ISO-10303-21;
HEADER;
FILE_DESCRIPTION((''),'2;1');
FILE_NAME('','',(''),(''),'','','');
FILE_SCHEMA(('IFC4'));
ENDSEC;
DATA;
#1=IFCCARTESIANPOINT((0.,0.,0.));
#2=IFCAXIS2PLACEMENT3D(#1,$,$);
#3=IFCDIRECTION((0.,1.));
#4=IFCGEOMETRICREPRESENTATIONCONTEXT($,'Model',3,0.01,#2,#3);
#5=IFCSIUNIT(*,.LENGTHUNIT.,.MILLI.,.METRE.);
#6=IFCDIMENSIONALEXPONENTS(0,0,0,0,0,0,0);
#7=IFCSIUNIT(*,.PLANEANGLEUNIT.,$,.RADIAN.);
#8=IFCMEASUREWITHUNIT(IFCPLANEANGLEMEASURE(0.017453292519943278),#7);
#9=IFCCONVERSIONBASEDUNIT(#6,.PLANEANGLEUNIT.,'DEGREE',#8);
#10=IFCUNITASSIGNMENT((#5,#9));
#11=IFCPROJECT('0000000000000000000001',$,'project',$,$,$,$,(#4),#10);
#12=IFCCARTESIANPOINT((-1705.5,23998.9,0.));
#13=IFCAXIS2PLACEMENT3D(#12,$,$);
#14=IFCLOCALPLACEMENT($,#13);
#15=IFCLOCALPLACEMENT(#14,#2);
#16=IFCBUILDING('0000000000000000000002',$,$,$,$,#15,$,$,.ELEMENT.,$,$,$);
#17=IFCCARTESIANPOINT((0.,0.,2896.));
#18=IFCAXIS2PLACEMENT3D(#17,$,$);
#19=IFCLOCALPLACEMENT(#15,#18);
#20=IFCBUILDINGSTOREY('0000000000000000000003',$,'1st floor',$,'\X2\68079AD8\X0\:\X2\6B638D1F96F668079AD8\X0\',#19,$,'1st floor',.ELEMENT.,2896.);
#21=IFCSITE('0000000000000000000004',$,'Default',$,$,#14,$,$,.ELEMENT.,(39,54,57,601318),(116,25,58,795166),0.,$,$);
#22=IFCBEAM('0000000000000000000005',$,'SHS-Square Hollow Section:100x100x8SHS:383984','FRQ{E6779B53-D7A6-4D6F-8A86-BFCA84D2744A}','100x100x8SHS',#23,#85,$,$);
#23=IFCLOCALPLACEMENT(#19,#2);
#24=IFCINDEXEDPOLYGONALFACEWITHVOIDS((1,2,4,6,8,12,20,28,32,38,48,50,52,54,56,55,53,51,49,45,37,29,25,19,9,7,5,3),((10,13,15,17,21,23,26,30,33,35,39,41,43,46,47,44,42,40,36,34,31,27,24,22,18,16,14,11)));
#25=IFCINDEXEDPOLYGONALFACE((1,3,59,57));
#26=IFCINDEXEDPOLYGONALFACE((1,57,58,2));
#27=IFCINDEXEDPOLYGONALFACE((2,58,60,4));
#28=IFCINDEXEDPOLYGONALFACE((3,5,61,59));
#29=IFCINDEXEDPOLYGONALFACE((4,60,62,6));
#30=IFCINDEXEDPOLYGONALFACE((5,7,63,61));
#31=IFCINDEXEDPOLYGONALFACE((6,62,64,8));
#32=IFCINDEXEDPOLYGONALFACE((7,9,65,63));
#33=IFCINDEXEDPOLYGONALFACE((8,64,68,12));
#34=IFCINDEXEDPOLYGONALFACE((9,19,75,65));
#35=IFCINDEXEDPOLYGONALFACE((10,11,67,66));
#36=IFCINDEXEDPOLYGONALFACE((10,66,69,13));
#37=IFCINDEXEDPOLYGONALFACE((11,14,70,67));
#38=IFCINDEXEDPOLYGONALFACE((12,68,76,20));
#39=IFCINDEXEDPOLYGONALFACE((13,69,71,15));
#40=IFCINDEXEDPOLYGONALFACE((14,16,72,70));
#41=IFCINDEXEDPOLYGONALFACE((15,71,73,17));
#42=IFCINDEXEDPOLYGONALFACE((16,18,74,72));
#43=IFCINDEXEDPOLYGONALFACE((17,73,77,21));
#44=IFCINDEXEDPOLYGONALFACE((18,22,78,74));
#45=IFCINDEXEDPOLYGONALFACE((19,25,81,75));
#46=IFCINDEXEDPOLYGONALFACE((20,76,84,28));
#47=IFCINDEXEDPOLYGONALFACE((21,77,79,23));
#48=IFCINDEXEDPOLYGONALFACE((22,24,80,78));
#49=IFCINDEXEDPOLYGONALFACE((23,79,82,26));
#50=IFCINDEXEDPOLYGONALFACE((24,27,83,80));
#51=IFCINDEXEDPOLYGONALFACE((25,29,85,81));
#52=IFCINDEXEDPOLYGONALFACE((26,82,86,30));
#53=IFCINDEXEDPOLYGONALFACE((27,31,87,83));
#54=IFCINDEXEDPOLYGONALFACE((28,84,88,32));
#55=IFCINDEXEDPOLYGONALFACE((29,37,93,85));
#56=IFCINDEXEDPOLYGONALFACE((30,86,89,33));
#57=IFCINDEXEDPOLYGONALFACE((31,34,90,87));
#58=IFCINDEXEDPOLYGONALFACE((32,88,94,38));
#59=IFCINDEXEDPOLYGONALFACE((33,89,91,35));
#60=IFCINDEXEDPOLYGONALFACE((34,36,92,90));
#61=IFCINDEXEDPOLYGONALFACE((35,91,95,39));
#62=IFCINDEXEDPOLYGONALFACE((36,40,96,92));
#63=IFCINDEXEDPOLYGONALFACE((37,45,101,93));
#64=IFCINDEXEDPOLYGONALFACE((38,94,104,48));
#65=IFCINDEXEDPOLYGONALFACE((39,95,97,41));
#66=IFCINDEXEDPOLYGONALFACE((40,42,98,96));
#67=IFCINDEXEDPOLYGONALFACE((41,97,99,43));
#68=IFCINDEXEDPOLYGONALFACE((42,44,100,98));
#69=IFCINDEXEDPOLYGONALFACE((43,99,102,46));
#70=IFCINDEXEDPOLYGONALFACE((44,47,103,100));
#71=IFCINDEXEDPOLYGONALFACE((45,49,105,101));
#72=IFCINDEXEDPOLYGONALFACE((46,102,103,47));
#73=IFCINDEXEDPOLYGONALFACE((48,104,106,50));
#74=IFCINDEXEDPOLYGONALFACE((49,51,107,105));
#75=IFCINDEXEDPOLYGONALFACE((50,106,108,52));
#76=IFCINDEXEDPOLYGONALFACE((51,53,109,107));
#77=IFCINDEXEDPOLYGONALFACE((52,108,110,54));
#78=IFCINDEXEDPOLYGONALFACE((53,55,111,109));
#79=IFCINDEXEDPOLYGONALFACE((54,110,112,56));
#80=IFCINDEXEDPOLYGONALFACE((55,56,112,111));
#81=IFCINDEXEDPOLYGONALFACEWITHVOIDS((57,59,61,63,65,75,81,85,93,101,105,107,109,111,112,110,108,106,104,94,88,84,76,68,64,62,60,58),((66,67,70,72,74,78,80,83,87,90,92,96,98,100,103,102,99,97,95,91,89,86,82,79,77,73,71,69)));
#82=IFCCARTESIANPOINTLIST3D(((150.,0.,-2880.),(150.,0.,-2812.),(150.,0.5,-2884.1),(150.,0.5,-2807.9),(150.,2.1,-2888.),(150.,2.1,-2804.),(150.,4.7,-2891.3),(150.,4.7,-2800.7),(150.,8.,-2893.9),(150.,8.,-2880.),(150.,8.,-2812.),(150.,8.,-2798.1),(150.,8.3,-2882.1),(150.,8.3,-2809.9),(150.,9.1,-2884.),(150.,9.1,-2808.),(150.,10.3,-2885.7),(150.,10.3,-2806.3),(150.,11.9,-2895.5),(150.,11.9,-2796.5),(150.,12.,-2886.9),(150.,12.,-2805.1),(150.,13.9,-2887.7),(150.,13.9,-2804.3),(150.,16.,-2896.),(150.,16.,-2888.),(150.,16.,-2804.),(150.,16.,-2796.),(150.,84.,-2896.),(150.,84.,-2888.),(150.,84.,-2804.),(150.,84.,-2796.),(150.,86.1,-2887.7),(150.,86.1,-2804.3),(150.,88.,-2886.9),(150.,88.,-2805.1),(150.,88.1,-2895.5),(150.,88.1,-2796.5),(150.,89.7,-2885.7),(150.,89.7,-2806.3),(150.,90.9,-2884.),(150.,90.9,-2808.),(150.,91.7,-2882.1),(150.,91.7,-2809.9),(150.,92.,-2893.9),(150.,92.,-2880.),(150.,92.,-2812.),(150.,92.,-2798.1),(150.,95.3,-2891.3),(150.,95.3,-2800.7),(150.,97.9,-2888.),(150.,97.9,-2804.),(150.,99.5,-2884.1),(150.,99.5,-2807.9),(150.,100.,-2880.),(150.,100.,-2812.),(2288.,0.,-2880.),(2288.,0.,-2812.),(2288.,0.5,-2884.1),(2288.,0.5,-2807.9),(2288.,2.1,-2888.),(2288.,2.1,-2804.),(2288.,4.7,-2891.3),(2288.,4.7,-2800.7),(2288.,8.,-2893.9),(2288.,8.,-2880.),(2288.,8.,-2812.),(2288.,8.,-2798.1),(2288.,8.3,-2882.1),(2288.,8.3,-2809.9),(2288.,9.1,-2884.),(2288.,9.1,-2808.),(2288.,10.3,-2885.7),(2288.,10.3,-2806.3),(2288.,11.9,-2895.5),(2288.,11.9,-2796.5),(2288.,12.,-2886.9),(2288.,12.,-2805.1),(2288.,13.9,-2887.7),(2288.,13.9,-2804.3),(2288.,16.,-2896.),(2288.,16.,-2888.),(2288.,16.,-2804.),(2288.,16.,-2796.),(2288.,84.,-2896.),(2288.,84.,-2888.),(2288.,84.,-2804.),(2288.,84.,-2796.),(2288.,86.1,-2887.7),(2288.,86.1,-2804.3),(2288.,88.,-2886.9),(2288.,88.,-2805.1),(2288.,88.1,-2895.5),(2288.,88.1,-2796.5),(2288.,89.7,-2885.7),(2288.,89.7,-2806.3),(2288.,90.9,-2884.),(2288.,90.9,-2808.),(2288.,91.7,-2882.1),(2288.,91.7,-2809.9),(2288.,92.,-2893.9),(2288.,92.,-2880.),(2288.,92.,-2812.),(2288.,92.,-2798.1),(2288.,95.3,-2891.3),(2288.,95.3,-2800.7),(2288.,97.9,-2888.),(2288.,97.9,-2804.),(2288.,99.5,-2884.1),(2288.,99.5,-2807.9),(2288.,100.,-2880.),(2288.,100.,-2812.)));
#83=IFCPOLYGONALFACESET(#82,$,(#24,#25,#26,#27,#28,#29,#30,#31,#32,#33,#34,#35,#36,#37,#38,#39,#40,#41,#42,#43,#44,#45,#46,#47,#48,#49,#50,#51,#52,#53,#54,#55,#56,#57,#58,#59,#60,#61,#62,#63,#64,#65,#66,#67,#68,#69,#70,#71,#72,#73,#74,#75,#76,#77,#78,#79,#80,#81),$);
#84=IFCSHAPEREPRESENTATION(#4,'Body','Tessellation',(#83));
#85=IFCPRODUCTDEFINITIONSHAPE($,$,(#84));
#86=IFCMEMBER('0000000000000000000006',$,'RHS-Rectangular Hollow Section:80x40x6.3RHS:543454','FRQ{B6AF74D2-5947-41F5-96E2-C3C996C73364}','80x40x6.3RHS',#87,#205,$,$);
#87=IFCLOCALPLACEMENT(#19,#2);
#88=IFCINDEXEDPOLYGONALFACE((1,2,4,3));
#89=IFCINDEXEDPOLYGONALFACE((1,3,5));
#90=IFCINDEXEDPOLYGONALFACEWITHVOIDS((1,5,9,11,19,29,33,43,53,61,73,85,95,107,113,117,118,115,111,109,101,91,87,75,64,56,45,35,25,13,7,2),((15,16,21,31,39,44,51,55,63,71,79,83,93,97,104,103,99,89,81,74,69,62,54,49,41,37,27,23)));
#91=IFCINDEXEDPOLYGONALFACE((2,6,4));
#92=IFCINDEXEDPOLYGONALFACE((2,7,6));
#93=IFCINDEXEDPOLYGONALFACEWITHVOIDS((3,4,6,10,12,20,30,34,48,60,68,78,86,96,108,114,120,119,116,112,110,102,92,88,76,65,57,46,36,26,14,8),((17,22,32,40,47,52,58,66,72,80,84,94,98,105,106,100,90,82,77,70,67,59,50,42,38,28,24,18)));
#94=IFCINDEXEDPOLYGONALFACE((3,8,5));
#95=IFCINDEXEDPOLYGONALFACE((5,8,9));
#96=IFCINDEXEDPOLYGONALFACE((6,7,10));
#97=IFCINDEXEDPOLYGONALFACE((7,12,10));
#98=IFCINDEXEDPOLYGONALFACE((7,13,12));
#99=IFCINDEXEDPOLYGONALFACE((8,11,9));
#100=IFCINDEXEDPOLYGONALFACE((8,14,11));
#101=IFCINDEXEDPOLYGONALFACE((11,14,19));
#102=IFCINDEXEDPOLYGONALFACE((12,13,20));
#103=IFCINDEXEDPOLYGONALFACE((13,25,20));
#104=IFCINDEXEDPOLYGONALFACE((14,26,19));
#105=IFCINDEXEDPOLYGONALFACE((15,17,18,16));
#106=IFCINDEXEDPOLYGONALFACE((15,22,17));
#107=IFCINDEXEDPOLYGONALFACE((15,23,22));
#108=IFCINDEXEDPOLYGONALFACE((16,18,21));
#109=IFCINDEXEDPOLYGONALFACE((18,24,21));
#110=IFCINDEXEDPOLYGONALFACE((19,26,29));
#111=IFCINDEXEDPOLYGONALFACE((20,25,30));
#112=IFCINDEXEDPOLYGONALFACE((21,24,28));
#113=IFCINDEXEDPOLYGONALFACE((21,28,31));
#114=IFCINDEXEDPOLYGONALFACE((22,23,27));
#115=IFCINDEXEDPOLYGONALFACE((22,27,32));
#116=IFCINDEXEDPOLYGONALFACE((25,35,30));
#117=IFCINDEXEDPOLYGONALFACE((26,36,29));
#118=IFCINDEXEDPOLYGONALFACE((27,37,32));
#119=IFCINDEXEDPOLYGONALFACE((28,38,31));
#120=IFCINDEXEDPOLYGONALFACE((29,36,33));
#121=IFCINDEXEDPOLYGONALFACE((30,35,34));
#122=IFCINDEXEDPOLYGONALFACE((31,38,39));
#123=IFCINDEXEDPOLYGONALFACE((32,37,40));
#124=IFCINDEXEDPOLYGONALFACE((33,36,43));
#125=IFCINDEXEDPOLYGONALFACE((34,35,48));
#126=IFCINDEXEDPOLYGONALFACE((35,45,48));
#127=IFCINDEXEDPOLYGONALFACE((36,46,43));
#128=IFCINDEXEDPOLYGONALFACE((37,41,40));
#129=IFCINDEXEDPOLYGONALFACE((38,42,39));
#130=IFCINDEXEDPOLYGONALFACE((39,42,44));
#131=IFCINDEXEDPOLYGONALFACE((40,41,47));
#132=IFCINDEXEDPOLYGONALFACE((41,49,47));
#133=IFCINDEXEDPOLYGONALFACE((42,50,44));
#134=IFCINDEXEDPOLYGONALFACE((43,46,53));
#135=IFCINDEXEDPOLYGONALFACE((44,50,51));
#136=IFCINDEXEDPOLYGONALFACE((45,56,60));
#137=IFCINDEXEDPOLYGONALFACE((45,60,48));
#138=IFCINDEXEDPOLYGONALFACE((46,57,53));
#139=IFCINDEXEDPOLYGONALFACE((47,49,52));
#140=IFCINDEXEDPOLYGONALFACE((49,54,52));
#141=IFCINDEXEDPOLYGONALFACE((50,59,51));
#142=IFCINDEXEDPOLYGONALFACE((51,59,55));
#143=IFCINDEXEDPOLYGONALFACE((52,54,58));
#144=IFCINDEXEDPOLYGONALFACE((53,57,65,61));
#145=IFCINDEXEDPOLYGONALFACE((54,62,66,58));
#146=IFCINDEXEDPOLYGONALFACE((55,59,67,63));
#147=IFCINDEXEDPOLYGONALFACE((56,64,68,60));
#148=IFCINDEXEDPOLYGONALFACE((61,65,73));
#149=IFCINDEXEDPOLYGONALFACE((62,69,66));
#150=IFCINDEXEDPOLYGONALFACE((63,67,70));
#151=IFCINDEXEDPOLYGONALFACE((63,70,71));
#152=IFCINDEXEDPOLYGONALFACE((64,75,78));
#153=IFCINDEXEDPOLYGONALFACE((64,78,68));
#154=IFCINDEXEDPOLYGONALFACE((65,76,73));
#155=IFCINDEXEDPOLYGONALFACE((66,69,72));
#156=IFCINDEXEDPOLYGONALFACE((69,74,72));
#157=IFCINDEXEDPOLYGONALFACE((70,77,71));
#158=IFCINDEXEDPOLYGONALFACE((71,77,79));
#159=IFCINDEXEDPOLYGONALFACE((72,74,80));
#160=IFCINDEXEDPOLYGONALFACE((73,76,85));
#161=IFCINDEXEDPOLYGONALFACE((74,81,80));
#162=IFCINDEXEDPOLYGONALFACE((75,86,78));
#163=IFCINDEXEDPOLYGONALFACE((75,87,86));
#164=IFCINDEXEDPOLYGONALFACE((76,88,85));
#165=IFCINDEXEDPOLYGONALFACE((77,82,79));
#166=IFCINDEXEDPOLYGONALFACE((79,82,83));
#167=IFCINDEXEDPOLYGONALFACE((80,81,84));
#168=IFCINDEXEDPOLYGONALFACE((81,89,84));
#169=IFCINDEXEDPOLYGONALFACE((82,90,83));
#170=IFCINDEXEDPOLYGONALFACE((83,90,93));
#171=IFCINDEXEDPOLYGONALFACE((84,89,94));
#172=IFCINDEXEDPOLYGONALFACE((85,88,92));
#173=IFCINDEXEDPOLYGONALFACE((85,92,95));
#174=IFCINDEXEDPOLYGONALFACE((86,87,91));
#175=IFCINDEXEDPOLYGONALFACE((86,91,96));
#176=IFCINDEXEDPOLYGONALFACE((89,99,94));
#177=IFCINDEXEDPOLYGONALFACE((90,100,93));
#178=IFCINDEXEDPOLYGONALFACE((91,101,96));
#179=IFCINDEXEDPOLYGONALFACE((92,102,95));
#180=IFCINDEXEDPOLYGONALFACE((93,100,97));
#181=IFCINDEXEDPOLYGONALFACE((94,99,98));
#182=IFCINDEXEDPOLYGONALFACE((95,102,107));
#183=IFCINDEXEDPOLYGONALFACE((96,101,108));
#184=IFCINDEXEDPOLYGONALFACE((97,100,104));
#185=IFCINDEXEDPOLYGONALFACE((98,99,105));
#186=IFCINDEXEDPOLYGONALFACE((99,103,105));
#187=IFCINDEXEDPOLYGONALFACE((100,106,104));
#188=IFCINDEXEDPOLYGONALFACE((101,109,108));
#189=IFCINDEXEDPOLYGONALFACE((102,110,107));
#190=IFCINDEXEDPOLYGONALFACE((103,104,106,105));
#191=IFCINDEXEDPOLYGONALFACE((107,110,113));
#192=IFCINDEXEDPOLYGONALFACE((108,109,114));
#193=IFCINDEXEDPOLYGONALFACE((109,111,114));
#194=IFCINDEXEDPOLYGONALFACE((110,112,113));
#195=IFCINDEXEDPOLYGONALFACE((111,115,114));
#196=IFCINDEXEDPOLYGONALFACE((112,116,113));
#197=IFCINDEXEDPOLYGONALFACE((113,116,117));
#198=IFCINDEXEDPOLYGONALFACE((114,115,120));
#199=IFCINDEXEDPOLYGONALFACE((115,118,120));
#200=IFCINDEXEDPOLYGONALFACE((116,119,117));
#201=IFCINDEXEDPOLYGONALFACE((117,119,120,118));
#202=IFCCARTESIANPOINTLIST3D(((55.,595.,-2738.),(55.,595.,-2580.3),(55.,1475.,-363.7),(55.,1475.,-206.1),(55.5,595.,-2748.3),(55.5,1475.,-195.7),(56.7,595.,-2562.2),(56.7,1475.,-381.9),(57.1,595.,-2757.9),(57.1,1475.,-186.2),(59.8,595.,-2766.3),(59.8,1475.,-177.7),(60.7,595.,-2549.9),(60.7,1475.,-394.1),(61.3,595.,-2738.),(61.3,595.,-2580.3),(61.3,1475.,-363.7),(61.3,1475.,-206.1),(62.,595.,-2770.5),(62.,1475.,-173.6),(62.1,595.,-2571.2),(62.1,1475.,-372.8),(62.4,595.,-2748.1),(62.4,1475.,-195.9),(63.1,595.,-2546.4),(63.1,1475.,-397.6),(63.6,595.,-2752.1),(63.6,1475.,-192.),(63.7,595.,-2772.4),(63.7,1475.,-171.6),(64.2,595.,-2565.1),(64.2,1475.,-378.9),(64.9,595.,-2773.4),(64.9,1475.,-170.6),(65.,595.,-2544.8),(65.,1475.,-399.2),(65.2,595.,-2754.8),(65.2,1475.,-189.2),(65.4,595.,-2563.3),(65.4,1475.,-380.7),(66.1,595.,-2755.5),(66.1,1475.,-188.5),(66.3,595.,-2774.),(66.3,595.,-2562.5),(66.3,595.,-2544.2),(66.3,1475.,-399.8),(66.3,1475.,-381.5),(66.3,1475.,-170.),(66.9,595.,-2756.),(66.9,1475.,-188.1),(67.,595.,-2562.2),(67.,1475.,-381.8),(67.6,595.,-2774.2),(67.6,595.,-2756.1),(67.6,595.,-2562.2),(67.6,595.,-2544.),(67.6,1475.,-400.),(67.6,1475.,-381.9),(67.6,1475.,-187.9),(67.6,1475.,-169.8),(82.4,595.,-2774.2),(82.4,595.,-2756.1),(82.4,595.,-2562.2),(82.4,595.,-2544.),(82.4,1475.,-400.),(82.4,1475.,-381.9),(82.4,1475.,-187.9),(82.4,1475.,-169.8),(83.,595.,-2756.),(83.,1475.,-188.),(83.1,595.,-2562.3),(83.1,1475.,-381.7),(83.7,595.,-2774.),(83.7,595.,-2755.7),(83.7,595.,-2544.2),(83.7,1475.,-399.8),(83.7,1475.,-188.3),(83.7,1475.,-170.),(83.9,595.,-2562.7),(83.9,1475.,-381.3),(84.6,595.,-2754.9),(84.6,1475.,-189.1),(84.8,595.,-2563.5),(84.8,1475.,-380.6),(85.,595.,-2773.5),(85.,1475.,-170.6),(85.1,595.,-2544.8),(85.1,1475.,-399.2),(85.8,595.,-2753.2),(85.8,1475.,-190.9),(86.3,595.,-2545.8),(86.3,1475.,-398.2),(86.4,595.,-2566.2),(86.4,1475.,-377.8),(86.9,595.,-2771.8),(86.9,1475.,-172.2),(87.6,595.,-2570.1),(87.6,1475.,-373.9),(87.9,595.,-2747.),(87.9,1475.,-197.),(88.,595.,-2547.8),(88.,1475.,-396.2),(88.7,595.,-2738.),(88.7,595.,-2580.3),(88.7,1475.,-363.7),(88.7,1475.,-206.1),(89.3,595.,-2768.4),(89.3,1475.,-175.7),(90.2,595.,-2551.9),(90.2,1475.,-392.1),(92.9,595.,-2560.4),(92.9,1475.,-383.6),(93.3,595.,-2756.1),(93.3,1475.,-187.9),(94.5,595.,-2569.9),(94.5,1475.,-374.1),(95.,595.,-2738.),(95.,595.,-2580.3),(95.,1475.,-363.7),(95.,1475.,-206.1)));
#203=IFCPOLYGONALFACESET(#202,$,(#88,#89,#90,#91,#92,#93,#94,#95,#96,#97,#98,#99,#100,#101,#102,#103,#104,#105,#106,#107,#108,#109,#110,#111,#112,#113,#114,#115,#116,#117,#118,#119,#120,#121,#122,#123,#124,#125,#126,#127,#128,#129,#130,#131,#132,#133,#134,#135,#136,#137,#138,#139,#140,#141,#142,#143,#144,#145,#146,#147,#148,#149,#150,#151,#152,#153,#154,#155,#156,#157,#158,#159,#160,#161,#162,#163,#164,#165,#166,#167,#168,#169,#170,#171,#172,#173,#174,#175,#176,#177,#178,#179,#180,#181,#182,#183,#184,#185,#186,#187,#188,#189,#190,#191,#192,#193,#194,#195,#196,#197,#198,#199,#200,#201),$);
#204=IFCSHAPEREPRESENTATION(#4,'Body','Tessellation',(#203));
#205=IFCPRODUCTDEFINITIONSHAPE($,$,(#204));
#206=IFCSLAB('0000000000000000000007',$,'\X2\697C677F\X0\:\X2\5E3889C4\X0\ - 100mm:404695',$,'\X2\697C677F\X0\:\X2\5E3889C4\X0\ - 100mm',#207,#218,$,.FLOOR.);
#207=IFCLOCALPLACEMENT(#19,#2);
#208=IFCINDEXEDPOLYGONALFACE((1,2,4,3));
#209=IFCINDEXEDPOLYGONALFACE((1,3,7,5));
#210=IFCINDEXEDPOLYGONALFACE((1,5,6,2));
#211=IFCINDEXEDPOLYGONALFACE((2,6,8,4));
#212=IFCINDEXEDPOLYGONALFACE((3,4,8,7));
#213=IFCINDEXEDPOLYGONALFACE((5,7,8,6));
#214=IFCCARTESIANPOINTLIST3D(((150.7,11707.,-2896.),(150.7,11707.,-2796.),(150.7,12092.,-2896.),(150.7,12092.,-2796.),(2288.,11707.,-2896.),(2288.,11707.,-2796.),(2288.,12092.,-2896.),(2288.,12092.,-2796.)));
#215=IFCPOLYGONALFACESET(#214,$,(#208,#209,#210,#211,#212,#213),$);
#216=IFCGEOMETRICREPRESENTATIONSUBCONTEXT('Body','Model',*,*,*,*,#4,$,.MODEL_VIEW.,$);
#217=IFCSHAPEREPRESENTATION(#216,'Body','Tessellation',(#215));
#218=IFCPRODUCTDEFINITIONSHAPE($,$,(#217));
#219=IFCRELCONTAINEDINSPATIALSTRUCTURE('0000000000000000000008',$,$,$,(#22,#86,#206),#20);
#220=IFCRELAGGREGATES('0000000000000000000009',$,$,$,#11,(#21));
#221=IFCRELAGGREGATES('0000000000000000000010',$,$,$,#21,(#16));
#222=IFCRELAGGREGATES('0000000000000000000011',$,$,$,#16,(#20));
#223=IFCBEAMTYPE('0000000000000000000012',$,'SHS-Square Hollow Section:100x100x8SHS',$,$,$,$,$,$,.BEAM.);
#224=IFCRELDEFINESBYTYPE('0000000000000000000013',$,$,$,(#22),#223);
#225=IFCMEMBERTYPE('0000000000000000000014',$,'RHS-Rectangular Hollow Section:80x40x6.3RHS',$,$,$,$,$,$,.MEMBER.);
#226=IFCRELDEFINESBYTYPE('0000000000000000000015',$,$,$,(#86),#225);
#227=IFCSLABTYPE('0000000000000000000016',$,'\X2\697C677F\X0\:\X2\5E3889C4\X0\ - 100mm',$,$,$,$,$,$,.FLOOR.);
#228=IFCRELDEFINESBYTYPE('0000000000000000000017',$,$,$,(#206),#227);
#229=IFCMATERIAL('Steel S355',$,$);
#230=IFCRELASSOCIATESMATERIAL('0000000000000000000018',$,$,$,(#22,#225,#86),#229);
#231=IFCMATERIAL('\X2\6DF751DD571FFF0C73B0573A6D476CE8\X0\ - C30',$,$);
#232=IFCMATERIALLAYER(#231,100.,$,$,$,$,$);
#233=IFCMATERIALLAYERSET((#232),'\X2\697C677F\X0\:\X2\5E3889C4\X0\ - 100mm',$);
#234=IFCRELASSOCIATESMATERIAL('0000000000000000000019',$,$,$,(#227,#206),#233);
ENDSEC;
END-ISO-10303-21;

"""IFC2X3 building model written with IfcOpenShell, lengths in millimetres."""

from ifc_helpers import new_model, entity, si_unit, converted_unit, direction, frame, origin, origin_2d, origin_2d_with_axis, place, context, subcontext, project, spatial, rectangle, hollow_rectangle, extrude, clip, halfspace, material, layer, layer_set, layer_usage, type_object, element, save


model = new_model("IFC2X3")

# Units and contexts
model_context = context("Model", 3, precision=0.01, world=origin(), true_north=direction((0.0, 1.0)))
body_context = subcontext(model_context, "Body", "Model", "MODEL_VIEW")
ifc_project = project(units=[si_unit("LENGTHUNIT", "METRE", prefix="MILLI"), converted_unit("PLANEANGLEUNIT", "DEGREE", entity("IfcPlaneAngleMeasure", 0.017453292519943278), si_unit("PLANEANGLEUNIT", "RADIAN"), dimensions=[0, 0, 0, 0, 0, 0, 0])], contexts=[model_context])

# Site, building, storey
site_placement = place(None, frame((-1705.5, 23998.9, 0.0)))
site = spatial("IfcSite", under=ifc_project, at=site_placement, Name="Default", CompositionType="ELEMENT", RefLatitude=(39, 54, 57, 601318), RefLongitude=(116, 25, 58, 795166), RefElevation=0.0)
building_placement = place(site_placement, origin())
building = spatial("IfcBuilding", under=site, at=building_placement, CompositionType="ELEMENT")
storey_placement = place(building_placement, frame((0.0, 0.0, 2896.0)))
storey = spatial("IfcBuildingStorey", under=building, at=storey_placement, Name="1st floor", ObjectType="标高:正负零标高", LongName="1st floor", CompositionType="ELEMENT", Elevation=2896.0)

# Shared definitions
ifc_material_1 = material(Name="Steel S355")

# Beam
beam_type_1 = type_object("IfcBeamType", Name="SHS-Square Hollow Section:100x100x8SHS", PredefinedType="BEAM")
beam_1_placement = place(storey_placement, frame((-57.7, 50.0, -2846.0), z_axis=(-1.0, 0.0, 0.0), x_axis=(0.0, -1.0, 0.0)))
element("IfcBeam", 1, at=beam_1_placement, inside=storey, type_object=beam_type_1, material=ifc_material_1, Name="SHS-Square Hollow Section:100x100x8SHS:383984", Description="FRQ{E6779B53-D7A6-4D6F-8A86-BFCA84D2744A}", ObjectType="100x100x8SHS", context=model_context, shape_type="Clipping", body=[
    clip(clip(extrude(hollow_rectangle(XDim=100.0, YDim=100.0, WallThickness=8.0, InnerFilletRadius=8.0, OuterFilletRadius=16.0, at=origin_2d()), origin(), (0.0, 0.0, -1.0), 2551.4), halfspace(frame((50.0, -50.0, -2345.7), z_axis=(0.0, 0.0, 1.0), x_axis=(1.0, 0.0, 0.0)), True)), halfspace(frame((50.0, -50.0, -207.7), z_axis=(0.0, 0.0, -1.0), x_axis=(-1.0, 0.0, 0.0)), True)),
])

# Member
member_type = type_object("IfcMemberType", Name="RHS-Rectangular Hollow Section:80x40x6.3RHS", PredefinedType="MEMBER", material=ifc_material_1)
member_1_placement = place(storey_placement, frame((75.0, 490.3, -2941.7), z_axis=(0.0, -0.347543, -0.937664), x_axis=(1.0, 0.0, 0.0)))
element("IfcMember", 2, at=member_1_placement, inside=storey, type_object=member_type, material=ifc_material_1, Name="RHS-Rectangular Hollow Section:80x40x6.3RHS:543454", Description="FRQ{B6AF74D2-5947-41F5-96E2-C3C996C73364}", ObjectType="80x40x6.3RHS", context=model_context, shape_type="Clipping", body=[
    clip(clip(extrude(hollow_rectangle(XDim=40.0, YDim=80.0, WallThickness=6.3, InnerFilletRadius=6.3, OuterFilletRadius=12.6, at=origin_2d()), origin(), (0.0, 0.0, -1.0), 3105.9), halfspace(frame((-75.0, -907.5, -385.0), z_axis=(0.0, 0.937664, 0.347543), x_axis=(1.0, 0.0, 0.0)), True)), halfspace(frame((-75.0, -82.3, -79.2), z_axis=(0.0, -0.937664, -0.347543), x_axis=(-1.0, 0.0, 0.0)), True)),
])

# Slab
ifc_material_2 = material(Name="混凝土，现场浇注 - C30")
ifc_layer_1 = layer(ifc_material_2, 100.0)
ifc_layer_set_1 = layer_set([ifc_layer_1], Name="楼板:常规 - 100mm")
ifc_layer_usage_1 = layer_usage(ifc_layer_set_1, "AXIS3", "POSITIVE", 0.0)
slab_type = type_object("IfcSlabType", Name="楼板:常规 - 100mm", PredefinedType="FLOOR", material=ifc_layer_set_1)
slab_1_placement = place(storey_placement, origin())
element("IfcSlab", 3, at=slab_1_placement, inside=storey, type_object=slab_type, material=ifc_layer_usage_1, Name="楼板:常规 - 100mm:404695", ObjectType="楼板:常规 - 100mm", PredefinedType="FLOOR", context=body_context, shape_type="SweptSolid", body=[
    extrude(rectangle(XDim=385.0, YDim=2137.3, at=origin_2d_with_axis()), frame((1219.3, 11899.5, -2796.0), z_axis=(0.0, 0.0, -1.0), x_axis=(0.0, 1.0, 0.0)), (0.0, 0.0, 1.0), 100.0),
])

save(model, "model.ifc")
